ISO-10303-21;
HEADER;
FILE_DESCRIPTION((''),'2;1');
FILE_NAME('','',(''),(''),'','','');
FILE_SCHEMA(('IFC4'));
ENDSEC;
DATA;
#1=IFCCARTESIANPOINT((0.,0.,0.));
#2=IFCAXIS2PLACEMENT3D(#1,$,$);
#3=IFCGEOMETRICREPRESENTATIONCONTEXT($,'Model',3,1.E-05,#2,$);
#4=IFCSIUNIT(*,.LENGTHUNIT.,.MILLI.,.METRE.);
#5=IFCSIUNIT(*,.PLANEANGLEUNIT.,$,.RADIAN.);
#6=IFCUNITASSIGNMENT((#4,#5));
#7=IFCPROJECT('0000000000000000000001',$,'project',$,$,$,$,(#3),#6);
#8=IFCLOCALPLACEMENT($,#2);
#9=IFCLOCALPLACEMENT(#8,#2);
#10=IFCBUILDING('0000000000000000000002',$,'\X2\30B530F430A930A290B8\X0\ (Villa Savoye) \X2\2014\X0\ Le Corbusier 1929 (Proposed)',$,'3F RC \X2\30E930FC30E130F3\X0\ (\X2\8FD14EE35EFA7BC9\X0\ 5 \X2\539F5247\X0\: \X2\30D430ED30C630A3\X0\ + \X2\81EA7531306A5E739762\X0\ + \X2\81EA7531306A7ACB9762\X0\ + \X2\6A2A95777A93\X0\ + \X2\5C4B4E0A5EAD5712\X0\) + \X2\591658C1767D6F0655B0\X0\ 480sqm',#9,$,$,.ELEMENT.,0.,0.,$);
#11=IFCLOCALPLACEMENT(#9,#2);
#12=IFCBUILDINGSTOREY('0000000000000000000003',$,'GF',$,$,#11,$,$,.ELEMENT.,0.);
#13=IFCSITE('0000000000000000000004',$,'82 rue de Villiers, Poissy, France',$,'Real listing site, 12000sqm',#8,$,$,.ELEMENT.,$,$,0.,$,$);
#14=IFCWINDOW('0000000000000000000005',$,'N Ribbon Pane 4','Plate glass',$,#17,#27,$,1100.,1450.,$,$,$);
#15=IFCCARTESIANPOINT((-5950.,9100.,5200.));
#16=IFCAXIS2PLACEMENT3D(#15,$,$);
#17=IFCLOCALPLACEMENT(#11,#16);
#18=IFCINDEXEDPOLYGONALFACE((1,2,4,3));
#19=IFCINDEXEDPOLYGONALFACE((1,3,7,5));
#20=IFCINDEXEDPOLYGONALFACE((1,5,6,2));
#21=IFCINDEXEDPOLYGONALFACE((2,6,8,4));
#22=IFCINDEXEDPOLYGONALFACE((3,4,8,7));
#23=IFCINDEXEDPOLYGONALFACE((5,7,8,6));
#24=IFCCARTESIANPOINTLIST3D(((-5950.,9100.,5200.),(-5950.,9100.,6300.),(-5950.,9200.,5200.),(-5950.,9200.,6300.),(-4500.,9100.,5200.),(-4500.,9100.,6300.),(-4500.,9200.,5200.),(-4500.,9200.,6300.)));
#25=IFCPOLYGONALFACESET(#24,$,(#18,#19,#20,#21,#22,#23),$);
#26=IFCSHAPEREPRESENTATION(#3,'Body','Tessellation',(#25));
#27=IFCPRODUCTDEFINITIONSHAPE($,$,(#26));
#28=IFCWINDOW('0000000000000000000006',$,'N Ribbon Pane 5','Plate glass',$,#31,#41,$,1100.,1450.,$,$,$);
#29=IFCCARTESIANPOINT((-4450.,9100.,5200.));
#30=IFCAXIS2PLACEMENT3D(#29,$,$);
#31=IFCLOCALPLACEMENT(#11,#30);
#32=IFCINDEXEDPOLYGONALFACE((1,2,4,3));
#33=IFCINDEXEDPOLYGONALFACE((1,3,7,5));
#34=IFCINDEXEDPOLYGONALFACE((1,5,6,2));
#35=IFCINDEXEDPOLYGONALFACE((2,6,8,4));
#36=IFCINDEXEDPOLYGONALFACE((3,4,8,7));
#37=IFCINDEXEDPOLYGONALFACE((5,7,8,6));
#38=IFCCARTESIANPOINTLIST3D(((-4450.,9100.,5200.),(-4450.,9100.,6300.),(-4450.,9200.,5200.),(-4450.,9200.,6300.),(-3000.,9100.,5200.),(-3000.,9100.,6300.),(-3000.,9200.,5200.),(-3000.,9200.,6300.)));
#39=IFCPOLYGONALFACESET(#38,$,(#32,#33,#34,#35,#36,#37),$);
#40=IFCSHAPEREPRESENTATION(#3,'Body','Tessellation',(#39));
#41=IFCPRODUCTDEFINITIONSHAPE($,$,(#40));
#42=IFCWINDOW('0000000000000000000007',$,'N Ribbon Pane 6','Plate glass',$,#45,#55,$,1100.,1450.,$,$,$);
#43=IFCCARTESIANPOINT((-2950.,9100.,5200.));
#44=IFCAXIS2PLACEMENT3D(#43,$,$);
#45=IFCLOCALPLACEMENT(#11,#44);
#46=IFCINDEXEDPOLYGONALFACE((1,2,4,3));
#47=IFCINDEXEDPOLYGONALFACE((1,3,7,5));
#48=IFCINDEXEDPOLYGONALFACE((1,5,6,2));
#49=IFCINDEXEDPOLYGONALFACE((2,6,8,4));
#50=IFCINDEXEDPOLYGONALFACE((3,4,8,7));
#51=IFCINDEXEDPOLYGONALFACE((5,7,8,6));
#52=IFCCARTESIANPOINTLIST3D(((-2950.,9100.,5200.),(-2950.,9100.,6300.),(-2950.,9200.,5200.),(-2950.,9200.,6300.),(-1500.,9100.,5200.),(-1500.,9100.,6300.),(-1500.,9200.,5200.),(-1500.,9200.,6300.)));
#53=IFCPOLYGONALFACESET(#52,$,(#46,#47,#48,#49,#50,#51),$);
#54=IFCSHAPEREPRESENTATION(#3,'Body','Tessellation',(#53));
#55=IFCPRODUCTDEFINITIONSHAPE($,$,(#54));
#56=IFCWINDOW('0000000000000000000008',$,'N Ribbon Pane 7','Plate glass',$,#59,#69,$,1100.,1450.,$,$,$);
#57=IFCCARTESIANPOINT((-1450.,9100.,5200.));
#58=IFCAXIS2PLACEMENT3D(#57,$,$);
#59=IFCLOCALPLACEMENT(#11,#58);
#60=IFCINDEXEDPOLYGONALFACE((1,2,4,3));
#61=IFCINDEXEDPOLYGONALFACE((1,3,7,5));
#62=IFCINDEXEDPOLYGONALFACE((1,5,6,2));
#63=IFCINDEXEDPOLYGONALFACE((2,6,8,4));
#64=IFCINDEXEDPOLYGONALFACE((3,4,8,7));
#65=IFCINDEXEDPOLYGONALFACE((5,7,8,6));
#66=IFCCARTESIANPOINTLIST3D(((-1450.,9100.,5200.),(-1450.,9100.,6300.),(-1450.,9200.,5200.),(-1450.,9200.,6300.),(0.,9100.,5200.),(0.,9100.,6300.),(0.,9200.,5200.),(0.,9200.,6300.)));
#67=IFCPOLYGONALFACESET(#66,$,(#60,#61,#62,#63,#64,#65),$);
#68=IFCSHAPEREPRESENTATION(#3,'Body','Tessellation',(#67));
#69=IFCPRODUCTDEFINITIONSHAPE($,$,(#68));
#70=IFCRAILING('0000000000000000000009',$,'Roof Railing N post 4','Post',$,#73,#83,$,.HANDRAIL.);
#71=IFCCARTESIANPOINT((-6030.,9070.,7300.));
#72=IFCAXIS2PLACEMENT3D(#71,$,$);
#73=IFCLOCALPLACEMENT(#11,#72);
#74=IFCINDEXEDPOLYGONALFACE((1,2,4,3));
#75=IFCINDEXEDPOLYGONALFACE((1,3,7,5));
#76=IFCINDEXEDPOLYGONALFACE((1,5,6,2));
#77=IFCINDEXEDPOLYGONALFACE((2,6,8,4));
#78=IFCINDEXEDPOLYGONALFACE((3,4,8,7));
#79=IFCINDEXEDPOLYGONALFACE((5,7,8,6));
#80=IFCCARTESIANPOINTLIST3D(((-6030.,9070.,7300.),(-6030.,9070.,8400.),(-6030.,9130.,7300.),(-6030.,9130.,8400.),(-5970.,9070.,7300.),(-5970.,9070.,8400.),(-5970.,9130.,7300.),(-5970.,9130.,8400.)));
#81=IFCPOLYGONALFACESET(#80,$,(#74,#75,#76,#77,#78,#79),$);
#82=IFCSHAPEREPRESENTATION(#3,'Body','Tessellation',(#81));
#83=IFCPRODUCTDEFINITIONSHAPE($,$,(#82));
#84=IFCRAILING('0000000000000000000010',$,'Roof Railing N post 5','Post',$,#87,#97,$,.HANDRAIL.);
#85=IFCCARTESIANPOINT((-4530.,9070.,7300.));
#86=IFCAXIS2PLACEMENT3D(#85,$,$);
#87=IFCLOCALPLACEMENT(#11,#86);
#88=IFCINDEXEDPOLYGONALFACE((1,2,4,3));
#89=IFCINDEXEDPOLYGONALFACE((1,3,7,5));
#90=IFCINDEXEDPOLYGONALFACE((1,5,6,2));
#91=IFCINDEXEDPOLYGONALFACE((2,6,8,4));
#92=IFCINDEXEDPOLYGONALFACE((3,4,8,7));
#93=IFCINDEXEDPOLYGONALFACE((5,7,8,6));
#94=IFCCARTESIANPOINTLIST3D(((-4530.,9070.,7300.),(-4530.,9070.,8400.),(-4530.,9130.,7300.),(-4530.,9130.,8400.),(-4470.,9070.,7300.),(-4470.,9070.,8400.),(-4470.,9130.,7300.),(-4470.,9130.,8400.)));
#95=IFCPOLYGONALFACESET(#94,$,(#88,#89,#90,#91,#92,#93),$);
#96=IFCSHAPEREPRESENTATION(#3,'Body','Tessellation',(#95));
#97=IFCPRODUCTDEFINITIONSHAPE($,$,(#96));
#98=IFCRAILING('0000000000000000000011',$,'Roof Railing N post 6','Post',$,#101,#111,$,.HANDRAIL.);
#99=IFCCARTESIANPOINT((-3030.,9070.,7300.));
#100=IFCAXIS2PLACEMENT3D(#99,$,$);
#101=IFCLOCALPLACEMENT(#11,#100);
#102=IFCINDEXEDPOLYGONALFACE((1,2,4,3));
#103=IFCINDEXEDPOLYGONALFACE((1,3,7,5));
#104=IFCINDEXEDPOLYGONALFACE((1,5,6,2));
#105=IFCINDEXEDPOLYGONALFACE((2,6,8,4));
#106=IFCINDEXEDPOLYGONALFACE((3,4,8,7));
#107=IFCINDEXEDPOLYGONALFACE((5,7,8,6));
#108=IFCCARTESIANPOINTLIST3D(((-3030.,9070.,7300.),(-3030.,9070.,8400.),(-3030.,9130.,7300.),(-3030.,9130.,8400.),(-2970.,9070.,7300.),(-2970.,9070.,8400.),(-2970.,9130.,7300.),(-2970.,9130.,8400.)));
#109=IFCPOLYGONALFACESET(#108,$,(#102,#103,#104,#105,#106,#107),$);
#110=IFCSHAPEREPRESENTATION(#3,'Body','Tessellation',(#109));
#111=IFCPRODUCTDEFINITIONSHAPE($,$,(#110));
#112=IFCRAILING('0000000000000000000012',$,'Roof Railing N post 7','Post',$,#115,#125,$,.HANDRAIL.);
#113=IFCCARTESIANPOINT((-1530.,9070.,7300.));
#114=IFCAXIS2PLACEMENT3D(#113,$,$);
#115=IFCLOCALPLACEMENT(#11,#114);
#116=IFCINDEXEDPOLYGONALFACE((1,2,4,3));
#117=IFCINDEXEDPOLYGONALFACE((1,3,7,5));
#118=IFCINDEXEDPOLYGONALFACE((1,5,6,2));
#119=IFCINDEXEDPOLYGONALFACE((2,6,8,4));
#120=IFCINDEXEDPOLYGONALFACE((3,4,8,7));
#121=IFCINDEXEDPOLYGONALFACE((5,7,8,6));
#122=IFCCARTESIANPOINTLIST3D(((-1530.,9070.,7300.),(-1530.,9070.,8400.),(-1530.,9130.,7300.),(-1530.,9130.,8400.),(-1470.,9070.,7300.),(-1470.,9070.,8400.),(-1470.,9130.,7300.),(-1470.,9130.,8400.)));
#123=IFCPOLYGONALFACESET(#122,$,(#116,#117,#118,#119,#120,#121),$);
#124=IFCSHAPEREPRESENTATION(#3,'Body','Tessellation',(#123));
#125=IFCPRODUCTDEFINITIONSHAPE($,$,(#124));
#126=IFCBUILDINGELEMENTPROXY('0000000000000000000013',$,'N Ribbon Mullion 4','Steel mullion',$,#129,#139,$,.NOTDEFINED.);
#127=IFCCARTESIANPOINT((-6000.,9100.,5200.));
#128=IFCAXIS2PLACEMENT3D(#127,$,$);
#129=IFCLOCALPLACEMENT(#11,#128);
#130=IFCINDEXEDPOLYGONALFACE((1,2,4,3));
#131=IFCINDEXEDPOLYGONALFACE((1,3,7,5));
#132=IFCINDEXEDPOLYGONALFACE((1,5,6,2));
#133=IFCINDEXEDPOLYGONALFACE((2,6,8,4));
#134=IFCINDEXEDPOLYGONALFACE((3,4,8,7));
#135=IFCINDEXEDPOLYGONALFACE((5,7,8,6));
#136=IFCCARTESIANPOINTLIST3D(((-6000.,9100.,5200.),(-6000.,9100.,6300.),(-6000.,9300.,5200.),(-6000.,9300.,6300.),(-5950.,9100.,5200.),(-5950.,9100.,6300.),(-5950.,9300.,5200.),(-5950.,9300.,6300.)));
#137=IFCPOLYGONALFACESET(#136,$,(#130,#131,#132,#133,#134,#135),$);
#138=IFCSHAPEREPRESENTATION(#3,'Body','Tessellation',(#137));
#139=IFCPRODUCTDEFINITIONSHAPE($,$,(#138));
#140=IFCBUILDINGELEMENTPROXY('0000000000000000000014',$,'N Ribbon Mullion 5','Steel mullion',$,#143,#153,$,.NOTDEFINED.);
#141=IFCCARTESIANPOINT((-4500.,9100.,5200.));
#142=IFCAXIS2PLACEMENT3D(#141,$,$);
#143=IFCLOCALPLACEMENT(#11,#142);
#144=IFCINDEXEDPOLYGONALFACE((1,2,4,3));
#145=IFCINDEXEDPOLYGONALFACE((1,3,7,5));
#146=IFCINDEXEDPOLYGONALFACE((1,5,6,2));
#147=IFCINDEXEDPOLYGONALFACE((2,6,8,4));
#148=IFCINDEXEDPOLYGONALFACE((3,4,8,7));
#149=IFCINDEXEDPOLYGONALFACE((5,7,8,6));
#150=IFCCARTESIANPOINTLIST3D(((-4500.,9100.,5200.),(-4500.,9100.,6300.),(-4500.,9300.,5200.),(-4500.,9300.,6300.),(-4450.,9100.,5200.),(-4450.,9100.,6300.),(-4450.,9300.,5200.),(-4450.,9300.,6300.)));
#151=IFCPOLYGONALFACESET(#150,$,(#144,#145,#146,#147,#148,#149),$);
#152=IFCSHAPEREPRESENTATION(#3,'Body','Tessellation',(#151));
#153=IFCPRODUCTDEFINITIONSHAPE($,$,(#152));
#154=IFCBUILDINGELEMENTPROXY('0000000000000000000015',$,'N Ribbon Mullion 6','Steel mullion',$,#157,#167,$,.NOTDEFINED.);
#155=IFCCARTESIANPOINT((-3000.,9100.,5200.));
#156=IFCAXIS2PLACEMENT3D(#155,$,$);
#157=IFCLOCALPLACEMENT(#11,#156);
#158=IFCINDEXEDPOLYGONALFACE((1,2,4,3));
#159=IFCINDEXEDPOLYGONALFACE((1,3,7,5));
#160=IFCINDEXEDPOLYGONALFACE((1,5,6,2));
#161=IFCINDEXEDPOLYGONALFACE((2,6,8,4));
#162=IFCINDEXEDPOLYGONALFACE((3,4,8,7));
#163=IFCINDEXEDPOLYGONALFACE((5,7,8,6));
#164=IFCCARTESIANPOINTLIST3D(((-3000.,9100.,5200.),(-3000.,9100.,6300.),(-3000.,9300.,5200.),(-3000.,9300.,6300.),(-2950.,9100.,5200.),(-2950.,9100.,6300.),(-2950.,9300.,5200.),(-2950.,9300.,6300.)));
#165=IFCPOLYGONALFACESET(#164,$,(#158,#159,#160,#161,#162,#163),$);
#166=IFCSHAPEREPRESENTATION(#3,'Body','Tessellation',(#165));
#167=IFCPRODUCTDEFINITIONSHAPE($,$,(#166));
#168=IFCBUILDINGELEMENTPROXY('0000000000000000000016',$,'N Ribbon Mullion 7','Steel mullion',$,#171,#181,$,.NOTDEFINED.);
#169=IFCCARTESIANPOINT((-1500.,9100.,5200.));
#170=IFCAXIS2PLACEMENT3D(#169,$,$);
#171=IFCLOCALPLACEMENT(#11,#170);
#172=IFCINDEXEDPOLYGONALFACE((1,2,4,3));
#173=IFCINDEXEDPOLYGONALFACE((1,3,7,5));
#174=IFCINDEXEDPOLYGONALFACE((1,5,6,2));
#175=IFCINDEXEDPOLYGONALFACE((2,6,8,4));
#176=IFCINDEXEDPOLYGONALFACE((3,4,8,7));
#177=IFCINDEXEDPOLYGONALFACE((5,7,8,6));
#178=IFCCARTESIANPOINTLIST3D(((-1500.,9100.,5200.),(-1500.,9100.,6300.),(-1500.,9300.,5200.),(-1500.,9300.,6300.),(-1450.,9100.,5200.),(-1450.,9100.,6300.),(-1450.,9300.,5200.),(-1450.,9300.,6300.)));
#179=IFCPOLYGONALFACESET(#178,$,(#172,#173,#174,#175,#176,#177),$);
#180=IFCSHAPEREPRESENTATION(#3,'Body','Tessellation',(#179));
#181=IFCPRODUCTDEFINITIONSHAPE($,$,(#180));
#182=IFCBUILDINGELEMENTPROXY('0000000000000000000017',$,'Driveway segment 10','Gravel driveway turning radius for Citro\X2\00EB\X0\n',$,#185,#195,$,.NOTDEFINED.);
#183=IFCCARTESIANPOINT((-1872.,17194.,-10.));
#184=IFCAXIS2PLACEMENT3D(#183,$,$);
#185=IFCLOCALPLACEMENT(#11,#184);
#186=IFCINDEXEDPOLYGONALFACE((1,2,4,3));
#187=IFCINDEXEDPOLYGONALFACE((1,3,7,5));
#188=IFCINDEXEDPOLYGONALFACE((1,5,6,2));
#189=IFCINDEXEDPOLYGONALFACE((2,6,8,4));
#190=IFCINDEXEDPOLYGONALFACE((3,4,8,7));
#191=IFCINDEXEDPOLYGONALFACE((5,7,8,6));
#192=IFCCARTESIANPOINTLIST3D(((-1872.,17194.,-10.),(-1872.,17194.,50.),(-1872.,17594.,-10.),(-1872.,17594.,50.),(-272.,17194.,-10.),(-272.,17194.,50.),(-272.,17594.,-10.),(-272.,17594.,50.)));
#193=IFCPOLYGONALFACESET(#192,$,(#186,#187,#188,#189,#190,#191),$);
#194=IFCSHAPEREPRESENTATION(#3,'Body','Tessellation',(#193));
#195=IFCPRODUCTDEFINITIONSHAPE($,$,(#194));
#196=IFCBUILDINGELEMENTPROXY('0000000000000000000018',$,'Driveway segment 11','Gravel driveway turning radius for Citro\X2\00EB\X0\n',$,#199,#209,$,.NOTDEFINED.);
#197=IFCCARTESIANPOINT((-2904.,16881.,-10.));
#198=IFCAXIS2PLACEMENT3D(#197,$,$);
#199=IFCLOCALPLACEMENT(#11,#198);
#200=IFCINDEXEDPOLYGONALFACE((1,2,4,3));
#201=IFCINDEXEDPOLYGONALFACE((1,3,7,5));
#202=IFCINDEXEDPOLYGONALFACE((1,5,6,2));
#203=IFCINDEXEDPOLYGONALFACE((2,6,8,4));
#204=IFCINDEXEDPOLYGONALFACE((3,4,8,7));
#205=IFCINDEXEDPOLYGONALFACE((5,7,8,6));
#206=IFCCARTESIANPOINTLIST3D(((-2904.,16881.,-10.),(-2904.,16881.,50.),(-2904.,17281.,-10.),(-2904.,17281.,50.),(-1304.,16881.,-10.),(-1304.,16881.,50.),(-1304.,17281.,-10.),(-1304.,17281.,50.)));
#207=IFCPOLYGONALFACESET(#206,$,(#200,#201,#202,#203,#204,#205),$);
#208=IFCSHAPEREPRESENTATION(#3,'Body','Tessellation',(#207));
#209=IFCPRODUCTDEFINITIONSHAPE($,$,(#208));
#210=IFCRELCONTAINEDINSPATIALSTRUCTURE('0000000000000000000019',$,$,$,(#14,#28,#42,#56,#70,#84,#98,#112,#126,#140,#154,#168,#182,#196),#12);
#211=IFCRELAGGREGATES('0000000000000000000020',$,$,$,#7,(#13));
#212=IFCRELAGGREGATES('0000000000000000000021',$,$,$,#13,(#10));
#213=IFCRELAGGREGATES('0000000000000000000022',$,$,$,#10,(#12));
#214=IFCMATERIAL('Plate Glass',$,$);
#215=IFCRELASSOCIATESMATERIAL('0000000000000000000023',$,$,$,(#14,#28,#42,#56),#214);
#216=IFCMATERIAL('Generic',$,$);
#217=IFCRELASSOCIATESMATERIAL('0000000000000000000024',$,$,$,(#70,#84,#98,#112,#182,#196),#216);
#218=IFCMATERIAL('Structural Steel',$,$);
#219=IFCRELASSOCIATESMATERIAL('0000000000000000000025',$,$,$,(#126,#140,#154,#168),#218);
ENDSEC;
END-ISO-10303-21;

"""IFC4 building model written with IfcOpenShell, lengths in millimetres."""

from ifc_helpers import new_model, si_unit, frame, frame_2d, origin, place, context, project, spatial, rectangle, extrude, material, element, save


model = new_model("IFC4")

# Units and contexts
model_context = context("Model", 3, precision=1e-05, world=origin())
ifc_project = project(units=[si_unit("LENGTHUNIT", "METRE", prefix="MILLI"), si_unit("PLANEANGLEUNIT", "RADIAN")], contexts=[model_context])

# Site, building, storey
site_placement = place(None, origin())
site = spatial("IfcSite", under=ifc_project, at=site_placement, Name="82 rue de Villiers, Poissy, France", ObjectType="Real listing site, 12000sqm", CompositionType="ELEMENT", RefElevation=0.0)
building_placement = place(site_placement, origin())
building = spatial("IfcBuilding", under=site, at=building_placement, Name="サヴォア邸 (Villa Savoye) — Le Corbusier 1929 (Proposed)", ObjectType="3F RC ラーメン (近代建築 5 原則: ピロティ + 自由な平面 + 自由な立面 + 横長窓 + 屋上庭園) + 外壁白漆喰 480sqm", CompositionType="ELEMENT", ElevationOfRefHeight=0.0, ElevationOfTerrain=0.0)
storey_placement = place(building_placement, origin())
storey = spatial("IfcBuildingStorey", under=building, at=storey_placement, Name="GF", CompositionType="ELEMENT", Elevation=0.0)

# Windows
ifc_material_1 = material(Name="Plate Glass")
window_1_placement = place(storey_placement, frame((-5950.0, 9100.0, 5200.0)))
element("IfcWindow", 1, at=window_1_placement, inside=storey, material=ifc_material_1, Name="N Ribbon Pane 4", Description="Plate glass", OverallHeight=1100.0, OverallWidth=1450.0, context=model_context, shape_type="SweptSolid", body=[
    extrude(rectangle(XDim=1450.0, YDim=100.0, at=frame_2d((725.0, 50.0))), frame((-5950.0, 9100.0, 5200.0)), (0.0, 0.0, 1.0), 1100.0),
])
window_2_placement = place(storey_placement, frame((-4450.0, 9100.0, 5200.0)))
element("IfcWindow", 2, at=window_2_placement, inside=storey, material=ifc_material_1, Name="N Ribbon Pane 5", Description="Plate glass", OverallHeight=1100.0, OverallWidth=1450.0, context=model_context, shape_type="SweptSolid", body=[
    extrude(rectangle(XDim=1450.0, YDim=100.0, at=frame_2d((725.0, 50.0))), frame((-4450.0, 9100.0, 5200.0)), (0.0, 0.0, 1.0), 1100.0),
])
window_3_placement = place(storey_placement, frame((-2950.0, 9100.0, 5200.0)))
element("IfcWindow", 3, at=window_3_placement, inside=storey, material=ifc_material_1, Name="N Ribbon Pane 6", Description="Plate glass", OverallHeight=1100.0, OverallWidth=1450.0, context=model_context, shape_type="SweptSolid", body=[
    extrude(rectangle(XDim=1450.0, YDim=100.0, at=frame_2d((725.0, 50.0))), frame((-2950.0, 9100.0, 5200.0)), (0.0, 0.0, 1.0), 1100.0),
])
window_4_placement = place(storey_placement, frame((-1450.0, 9100.0, 5200.0)))
element("IfcWindow", 4, at=window_4_placement, inside=storey, material=ifc_material_1, Name="N Ribbon Pane 7", Description="Plate glass", OverallHeight=1100.0, OverallWidth=1450.0, context=model_context, shape_type="SweptSolid", body=[
    extrude(rectangle(XDim=1450.0, YDim=100.0, at=frame_2d((725.0, 50.0))), frame((-1450.0, 9100.0, 5200.0)), (0.0, 0.0, 1.0), 1100.0),
])

# Railings
ifc_material_2 = material(Name="Generic")
railing_1_placement = place(storey_placement, frame((-6030.0, 9070.0, 7300.0)))
element("IfcRailing", 5, at=railing_1_placement, inside=storey, material=ifc_material_2, Name="Roof Railing N post 4", Description="Post", PredefinedType="HANDRAIL", context=model_context, shape_type="SweptSolid", body=[
    extrude(rectangle(XDim=60.0, YDim=60.0, at=frame_2d((30.0, 30.0))), frame((-6030.0, 9070.0, 7300.0)), (0.0, 0.0, 1.0), 1100.0),
])
railing_2_placement = place(storey_placement, frame((-4530.0, 9070.0, 7300.0)))
element("IfcRailing", 6, at=railing_2_placement, inside=storey, material=ifc_material_2, Name="Roof Railing N post 5", Description="Post", PredefinedType="HANDRAIL", context=model_context, shape_type="SweptSolid", body=[
    extrude(rectangle(XDim=60.0, YDim=60.0, at=frame_2d((30.0, 30.0))), frame((-4530.0, 9070.0, 7300.0)), (0.0, 0.0, 1.0), 1100.0),
])
railing_3_placement = place(storey_placement, frame((-3030.0, 9070.0, 7300.0)))
element("IfcRailing", 7, at=railing_3_placement, inside=storey, material=ifc_material_2, Name="Roof Railing N post 6", Description="Post", PredefinedType="HANDRAIL", context=model_context, shape_type="SweptSolid", body=[
    extrude(rectangle(XDim=60.0, YDim=60.0, at=frame_2d((30.0, 30.0))), frame((-3030.0, 9070.0, 7300.0)), (0.0, 0.0, 1.0), 1100.0),
])
railing_4_placement = place(storey_placement, frame((-1530.0, 9070.0, 7300.0)))
element("IfcRailing", 8, at=railing_4_placement, inside=storey, material=ifc_material_2, Name="Roof Railing N post 7", Description="Post", PredefinedType="HANDRAIL", context=model_context, shape_type="SweptSolid", body=[
    extrude(rectangle(XDim=60.0, YDim=60.0, at=frame_2d((30.0, 30.0))), frame((-1530.0, 9070.0, 7300.0)), (0.0, 0.0, 1.0), 1100.0),
])

# Building element proxies
ifc_material_3 = material(Name="Structural Steel")
proxy_1_placement = place(storey_placement, frame((-6000.0, 9100.0, 5200.0)))
element("IfcBuildingElementProxy", 9, at=proxy_1_placement, inside=storey, material=ifc_material_3, Name="N Ribbon Mullion 4", Description="Steel mullion", PredefinedType="NOTDEFINED", context=model_context, shape_type="SweptSolid", body=[
    extrude(rectangle(XDim=50.0, YDim=200.0, at=frame_2d((25.0, 100.0))), frame((-6000.0, 9100.0, 5200.0)), (0.0, 0.0, 1.0), 1100.0),
])
proxy_2_placement = place(storey_placement, frame((-4500.0, 9100.0, 5200.0)))
element("IfcBuildingElementProxy", 10, at=proxy_2_placement, inside=storey, material=ifc_material_3, Name="N Ribbon Mullion 5", Description="Steel mullion", PredefinedType="NOTDEFINED", context=model_context, shape_type="SweptSolid", body=[
    extrude(rectangle(XDim=50.0, YDim=200.0, at=frame_2d((25.0, 100.0))), frame((-4500.0, 9100.0, 5200.0)), (0.0, 0.0, 1.0), 1100.0),
])
proxy_3_placement = place(storey_placement, frame((-3000.0, 9100.0, 5200.0)))
element("IfcBuildingElementProxy", 11, at=proxy_3_placement, inside=storey, material=ifc_material_3, Name="N Ribbon Mullion 6", Description="Steel mullion", PredefinedType="NOTDEFINED", context=model_context, shape_type="SweptSolid", body=[
    extrude(rectangle(XDim=50.0, YDim=200.0, at=frame_2d((25.0, 100.0))), frame((-3000.0, 9100.0, 5200.0)), (0.0, 0.0, 1.0), 1100.0),
])
proxy_4_placement = place(storey_placement, frame((-1500.0, 9100.0, 5200.0)))
element("IfcBuildingElementProxy", 12, at=proxy_4_placement, inside=storey, material=ifc_material_3, Name="N Ribbon Mullion 7", Description="Steel mullion", PredefinedType="NOTDEFINED", context=model_context, shape_type="SweptSolid", body=[
    extrude(rectangle(XDim=50.0, YDim=200.0, at=frame_2d((25.0, 100.0))), frame((-1500.0, 9100.0, 5200.0)), (0.0, 0.0, 1.0), 1100.0),
])
proxy_5_placement = place(storey_placement, frame((-1872.0, 17194.0, -10.0)))
element("IfcBuildingElementProxy", 13, at=proxy_5_placement, inside=storey, material=ifc_material_2, Name="Driveway segment 10", Description="Gravel driveway turning radius for Citroën", PredefinedType="NOTDEFINED", context=model_context, shape_type="SweptSolid", body=[
    extrude(rectangle(XDim=1600.0, YDim=400.0, at=frame_2d((800.0, 200.0))), frame((-1872.0, 17194.0, -10.0)), (0.0, 0.0, 1.0), 60.0),
])
proxy_6_placement = place(storey_placement, frame((-2904.0, 16881.0, -10.0)))
element("IfcBuildingElementProxy", 14, at=proxy_6_placement, inside=storey, material=ifc_material_2, Name="Driveway segment 11", Description="Gravel driveway turning radius for Citroën", PredefinedType="NOTDEFINED", context=model_context, shape_type="SweptSolid", body=[
    extrude(rectangle(XDim=1600.0, YDim=400.0, at=frame_2d((800.0, 200.0))), frame((-2904.0, 16881.0, -10.0)), (0.0, 0.0, 1.0), 60.0),
])

save(model, "model.ifc")
